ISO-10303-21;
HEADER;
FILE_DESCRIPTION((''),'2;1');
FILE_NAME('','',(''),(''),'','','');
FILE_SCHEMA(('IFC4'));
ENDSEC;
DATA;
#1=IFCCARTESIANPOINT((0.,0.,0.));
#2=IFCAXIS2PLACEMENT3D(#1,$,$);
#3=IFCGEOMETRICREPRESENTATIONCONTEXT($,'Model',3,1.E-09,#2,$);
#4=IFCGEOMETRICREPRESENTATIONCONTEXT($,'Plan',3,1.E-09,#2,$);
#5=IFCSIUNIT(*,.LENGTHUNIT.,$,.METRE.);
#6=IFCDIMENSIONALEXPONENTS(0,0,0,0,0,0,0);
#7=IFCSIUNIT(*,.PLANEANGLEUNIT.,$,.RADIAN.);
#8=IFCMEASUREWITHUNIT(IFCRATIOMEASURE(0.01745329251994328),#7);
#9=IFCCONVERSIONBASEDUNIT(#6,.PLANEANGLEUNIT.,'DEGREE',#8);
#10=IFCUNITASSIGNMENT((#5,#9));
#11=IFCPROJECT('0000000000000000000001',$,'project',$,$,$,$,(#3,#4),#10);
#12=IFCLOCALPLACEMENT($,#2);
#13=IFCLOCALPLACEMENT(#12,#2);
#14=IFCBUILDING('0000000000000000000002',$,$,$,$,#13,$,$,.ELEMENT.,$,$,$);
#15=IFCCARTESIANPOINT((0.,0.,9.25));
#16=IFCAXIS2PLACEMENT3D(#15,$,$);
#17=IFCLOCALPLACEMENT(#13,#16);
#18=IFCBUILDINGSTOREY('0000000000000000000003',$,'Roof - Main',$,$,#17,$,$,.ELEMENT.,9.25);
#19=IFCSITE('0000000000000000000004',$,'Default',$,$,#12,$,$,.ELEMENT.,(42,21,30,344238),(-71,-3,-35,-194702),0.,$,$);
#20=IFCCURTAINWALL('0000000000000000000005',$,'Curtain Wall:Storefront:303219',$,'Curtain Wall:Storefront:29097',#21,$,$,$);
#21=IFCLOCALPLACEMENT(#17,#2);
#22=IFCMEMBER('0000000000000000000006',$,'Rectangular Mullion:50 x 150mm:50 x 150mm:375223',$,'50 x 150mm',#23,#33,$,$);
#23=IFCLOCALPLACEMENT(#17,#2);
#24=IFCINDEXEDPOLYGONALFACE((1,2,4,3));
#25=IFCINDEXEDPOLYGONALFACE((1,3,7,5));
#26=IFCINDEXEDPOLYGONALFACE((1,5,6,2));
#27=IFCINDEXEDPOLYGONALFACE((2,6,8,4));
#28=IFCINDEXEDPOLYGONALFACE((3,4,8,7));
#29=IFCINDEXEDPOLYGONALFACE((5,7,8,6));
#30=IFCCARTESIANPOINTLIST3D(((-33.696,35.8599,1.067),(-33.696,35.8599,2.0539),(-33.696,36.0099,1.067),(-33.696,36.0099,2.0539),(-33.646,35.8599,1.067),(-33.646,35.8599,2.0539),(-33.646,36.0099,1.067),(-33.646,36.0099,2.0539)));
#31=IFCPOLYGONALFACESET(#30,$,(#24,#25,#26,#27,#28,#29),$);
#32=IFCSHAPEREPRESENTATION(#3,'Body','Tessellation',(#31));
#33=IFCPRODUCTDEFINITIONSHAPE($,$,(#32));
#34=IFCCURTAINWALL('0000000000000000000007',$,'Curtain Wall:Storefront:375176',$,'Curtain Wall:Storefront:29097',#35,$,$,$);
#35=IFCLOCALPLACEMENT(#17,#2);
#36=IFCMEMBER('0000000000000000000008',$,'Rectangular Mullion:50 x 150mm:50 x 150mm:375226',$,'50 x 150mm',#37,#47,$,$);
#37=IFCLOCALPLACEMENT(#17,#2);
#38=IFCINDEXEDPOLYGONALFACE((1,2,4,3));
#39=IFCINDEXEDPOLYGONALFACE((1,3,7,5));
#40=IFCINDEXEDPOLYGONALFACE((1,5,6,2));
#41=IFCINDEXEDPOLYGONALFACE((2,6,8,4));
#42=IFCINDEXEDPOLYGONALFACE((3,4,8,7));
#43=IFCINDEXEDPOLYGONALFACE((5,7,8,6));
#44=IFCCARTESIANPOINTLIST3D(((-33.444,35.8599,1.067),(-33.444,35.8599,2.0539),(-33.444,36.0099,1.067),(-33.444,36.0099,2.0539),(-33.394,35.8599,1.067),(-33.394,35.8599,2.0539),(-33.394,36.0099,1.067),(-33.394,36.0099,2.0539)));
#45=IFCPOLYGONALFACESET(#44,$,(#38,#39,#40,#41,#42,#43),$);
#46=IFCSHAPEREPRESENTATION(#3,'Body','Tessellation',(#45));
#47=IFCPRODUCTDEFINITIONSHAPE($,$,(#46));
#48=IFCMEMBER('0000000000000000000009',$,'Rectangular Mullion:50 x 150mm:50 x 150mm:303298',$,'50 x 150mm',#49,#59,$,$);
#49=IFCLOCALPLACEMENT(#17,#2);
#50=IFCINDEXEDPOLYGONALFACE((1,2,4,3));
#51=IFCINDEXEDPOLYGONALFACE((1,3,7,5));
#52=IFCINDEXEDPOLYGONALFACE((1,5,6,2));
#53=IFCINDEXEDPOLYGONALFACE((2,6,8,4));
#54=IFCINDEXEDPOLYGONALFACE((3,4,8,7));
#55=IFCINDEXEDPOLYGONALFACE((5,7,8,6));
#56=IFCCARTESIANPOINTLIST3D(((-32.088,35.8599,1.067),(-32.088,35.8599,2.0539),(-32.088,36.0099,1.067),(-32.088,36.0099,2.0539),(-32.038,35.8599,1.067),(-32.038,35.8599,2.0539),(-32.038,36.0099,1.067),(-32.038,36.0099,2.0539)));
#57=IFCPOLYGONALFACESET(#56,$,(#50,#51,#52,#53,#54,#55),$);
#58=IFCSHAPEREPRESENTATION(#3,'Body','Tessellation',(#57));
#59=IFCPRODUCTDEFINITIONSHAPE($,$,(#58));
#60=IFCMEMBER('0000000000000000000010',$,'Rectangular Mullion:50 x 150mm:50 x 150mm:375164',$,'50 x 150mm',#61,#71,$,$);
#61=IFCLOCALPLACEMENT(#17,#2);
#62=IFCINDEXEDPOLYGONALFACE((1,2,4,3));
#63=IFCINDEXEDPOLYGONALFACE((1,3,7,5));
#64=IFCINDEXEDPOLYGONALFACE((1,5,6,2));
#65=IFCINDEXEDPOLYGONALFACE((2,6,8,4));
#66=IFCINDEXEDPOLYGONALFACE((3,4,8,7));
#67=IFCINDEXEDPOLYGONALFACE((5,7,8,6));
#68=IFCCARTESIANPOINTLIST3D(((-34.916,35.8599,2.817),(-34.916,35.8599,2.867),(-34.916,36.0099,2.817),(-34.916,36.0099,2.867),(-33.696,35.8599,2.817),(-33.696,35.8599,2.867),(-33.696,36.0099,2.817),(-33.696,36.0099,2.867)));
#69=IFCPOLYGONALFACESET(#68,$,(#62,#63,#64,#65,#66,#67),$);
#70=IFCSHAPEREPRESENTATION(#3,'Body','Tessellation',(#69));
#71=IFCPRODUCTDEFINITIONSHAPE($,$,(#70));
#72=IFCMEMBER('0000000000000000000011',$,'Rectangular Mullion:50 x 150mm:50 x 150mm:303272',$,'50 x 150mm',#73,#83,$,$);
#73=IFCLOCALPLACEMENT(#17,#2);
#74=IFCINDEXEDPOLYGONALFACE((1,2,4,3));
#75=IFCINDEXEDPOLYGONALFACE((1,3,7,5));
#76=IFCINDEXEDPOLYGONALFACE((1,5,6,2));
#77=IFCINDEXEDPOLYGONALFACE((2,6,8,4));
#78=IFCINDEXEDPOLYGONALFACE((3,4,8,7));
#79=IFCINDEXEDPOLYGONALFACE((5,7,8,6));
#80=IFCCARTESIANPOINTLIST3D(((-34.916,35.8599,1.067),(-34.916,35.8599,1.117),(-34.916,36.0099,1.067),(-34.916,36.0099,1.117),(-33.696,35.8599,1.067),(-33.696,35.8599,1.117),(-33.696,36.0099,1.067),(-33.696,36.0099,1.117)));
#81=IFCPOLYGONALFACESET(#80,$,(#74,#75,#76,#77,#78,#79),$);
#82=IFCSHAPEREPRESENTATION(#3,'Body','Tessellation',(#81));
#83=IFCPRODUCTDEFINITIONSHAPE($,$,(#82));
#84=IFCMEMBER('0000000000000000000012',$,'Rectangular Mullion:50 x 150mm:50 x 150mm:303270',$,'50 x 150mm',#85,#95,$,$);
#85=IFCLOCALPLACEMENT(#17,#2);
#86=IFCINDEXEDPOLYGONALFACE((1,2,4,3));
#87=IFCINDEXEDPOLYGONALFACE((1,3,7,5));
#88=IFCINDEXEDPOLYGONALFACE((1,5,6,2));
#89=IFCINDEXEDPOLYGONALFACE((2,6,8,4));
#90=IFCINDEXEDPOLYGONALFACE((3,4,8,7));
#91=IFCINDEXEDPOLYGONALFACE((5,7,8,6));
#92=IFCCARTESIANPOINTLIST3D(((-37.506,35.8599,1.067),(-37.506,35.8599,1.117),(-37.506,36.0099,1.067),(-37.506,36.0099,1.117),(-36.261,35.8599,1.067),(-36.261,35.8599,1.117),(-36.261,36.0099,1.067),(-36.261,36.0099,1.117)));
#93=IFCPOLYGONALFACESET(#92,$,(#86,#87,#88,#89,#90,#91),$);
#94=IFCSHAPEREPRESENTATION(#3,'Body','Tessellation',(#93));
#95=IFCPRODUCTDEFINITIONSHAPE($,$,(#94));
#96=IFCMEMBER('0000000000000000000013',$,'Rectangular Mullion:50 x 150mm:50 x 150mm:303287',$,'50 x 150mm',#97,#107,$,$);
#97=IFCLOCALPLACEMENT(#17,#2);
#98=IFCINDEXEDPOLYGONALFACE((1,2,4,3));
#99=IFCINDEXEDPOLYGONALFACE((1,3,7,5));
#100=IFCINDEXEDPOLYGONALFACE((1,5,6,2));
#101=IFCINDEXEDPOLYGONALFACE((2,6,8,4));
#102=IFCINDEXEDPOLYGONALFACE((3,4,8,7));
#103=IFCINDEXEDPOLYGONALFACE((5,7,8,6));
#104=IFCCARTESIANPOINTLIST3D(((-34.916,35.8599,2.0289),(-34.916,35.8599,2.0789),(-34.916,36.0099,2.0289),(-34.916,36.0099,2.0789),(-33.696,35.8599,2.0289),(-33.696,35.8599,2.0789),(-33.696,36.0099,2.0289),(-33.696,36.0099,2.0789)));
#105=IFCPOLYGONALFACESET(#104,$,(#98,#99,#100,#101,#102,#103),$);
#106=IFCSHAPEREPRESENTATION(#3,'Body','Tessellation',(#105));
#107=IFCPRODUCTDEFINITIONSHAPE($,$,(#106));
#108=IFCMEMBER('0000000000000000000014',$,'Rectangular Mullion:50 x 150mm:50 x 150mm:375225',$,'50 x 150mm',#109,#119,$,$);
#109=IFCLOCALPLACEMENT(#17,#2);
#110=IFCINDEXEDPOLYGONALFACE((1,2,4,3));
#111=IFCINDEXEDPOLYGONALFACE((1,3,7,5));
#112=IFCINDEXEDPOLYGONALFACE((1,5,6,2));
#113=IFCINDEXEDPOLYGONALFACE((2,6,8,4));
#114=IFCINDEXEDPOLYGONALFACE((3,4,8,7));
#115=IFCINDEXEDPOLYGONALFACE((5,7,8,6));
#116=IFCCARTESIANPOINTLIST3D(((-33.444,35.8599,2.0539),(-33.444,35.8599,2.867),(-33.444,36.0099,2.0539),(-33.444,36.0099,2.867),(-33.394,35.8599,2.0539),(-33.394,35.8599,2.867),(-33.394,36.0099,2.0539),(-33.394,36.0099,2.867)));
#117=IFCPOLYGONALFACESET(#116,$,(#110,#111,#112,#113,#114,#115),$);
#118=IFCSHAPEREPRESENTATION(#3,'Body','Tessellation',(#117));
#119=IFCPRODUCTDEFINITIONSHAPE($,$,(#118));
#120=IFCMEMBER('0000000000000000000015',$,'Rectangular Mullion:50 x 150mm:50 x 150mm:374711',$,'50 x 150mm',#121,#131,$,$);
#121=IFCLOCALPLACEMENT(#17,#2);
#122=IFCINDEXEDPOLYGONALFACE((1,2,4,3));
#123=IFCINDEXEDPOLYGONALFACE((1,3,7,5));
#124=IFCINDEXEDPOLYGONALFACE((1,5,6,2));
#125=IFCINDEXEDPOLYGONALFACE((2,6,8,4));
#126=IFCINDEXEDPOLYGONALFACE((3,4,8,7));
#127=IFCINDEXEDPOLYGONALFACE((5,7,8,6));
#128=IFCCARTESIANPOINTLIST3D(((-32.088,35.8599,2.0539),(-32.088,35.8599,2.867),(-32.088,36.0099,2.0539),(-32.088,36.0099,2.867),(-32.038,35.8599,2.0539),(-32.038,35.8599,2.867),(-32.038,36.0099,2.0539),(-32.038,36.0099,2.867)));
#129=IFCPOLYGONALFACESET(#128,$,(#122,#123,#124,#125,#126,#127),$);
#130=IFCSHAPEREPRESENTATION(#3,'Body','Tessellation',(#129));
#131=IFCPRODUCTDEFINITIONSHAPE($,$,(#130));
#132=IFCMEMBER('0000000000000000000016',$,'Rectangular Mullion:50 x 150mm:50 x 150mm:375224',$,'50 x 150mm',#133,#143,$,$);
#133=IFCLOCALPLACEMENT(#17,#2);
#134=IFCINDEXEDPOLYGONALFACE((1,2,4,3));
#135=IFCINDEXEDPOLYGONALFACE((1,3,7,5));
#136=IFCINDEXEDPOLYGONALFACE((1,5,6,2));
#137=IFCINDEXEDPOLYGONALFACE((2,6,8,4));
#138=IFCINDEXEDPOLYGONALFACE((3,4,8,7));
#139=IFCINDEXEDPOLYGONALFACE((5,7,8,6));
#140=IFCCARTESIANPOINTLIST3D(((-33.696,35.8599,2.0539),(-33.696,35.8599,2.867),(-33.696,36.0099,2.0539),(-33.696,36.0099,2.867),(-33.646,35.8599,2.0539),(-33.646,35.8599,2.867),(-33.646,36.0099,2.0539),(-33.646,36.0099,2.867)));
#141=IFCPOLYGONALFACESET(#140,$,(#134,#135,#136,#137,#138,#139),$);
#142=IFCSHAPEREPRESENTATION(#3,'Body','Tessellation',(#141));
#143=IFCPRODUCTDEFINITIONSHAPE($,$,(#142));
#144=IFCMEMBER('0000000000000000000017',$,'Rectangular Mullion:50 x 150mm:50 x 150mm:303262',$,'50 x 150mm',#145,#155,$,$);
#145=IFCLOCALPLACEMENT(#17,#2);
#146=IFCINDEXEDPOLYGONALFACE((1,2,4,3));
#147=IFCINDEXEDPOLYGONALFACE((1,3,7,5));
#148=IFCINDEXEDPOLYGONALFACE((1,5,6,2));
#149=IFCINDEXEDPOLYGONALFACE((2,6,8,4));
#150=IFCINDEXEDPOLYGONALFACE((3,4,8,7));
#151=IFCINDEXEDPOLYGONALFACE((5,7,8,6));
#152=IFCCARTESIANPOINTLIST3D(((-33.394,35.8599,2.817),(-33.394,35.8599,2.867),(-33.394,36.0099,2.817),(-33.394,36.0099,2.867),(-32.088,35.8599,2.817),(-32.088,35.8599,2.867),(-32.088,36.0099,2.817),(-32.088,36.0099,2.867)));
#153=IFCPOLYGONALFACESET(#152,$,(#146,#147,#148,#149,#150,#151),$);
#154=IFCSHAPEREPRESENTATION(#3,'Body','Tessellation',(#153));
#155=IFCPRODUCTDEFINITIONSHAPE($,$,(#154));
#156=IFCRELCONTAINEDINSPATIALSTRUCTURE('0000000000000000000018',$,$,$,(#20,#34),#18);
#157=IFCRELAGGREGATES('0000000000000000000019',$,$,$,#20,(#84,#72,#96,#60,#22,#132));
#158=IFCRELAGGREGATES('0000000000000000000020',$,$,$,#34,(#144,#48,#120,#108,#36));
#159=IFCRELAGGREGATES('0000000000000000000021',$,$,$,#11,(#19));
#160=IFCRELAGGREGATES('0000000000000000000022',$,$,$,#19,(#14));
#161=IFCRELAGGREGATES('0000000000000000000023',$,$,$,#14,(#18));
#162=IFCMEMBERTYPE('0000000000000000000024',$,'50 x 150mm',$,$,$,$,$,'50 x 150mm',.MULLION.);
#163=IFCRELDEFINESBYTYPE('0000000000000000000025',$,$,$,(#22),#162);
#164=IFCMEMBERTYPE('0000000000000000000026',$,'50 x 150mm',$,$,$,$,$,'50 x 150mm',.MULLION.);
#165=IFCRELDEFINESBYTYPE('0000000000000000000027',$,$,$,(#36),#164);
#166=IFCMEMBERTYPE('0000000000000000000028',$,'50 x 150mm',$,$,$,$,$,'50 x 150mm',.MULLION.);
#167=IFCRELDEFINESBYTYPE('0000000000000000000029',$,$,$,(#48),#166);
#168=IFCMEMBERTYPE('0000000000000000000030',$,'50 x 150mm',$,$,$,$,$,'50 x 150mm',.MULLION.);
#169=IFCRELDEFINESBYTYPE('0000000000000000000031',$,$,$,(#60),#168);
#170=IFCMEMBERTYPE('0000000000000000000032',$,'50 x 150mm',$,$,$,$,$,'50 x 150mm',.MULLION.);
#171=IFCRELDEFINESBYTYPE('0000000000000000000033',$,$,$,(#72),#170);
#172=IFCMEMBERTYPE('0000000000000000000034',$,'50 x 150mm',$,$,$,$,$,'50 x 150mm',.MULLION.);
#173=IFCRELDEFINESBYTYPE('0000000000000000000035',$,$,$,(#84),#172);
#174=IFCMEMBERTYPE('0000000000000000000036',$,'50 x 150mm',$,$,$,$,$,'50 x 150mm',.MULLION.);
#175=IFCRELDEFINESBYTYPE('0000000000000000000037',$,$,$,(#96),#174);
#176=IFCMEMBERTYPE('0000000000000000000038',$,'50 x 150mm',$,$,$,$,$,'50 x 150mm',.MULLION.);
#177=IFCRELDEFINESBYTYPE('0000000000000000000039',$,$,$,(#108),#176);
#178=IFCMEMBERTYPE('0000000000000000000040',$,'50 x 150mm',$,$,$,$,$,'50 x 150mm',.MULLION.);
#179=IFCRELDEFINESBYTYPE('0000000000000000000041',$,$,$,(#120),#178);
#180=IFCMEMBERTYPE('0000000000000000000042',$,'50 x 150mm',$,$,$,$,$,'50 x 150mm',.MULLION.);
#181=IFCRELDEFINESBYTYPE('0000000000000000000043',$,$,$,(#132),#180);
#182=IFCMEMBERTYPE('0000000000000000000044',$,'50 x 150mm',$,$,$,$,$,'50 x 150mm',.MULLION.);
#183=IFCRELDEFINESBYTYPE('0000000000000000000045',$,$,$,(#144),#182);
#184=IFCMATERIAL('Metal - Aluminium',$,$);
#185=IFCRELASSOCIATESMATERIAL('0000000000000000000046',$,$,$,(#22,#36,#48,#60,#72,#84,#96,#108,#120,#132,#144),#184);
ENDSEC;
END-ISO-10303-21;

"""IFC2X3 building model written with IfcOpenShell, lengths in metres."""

from ifc_helpers import new_model, entity, si_unit, converted_unit, frame, origin, origin_2d_with_axis, place, context, project, spatial, rectangle, extrude, source, transform, mapped, material, type_object, type_shapes, element, aggregate, save


model = new_model("IFC2X3")

# Units and contexts
model_context = context("Model", 3, precision=1e-09, world=origin())
plan_context = context("Plan", 3, precision=1e-09, world=origin())
ifc_project = project(units=[si_unit("LENGTHUNIT", "METRE"), converted_unit("PLANEANGLEUNIT", "DEGREE", entity("IfcRatioMeasure", 0.01745329251994328), si_unit("PLANEANGLEUNIT", "RADIAN"), dimensions=[0, 0, 0, 0, 0, 0, 0])], contexts=[model_context, plan_context])

# Site, building, storey
site_placement = place(None, origin())
site = spatial("IfcSite", under=ifc_project, at=site_placement, Name="Default", CompositionType="ELEMENT", RefLatitude=(42, 21, 30, 344238), RefLongitude=(-71, -3, -35, -194702), RefElevation=0.0)
building_placement = place(site_placement, origin())
building = spatial("IfcBuilding", under=site, at=building_placement, CompositionType="ELEMENT")
storey_placement = place(building_placement, frame((0.0, 0.0, 9.25)))
storey = spatial("IfcBuildingStorey", under=building, at=storey_placement, Name="Roof - Main", CompositionType="ELEMENT", Elevation=9.25)

# Curtain wall, member
curtain_wall_1_placement = place(storey_placement, origin())
curtain_wall_1 = element("IfcCurtainWall", 1, at=curtain_wall_1_placement, inside=storey, Name="Curtain Wall:Storefront:303219", ObjectType="Curtain Wall:Storefront:29097")
ifc_material_1 = material(Name="Metal - Aluminium")
member_type_1 = type_object("IfcMemberType", Name="50 x 150mm", ElementType="50 x 150mm", PredefinedType="MULLION")
shared_shape_1 = source(origin(), model_context, "Body", "SweptSolid", [
    extrude(rectangle(XDim=0.05, YDim=0.15, at=origin_2d_with_axis()), frame((-0.025, 0.0, -0.9869), z_axis=(0.0, 0.0, 1.0), x_axis=(-1.0, 0.0, 0.0)), (0.0, 0.0, 1.0), 0.9869),
])
type_shapes(member_type_1, [shared_shape_1])
member_1_placement = place(storey_placement, frame((-33.646, 35.9349, 1.067), z_axis=(0.0, 0.0, -1.0), x_axis=(1.0, 0.0, 0.0)))
member_1 = element("IfcMember", 2, at=member_1_placement, type_object=member_type_1, material=ifc_material_1, Name="Rectangular Mullion:50 x 150mm:50 x 150mm:375223", ObjectType="50 x 150mm", context=model_context, shape_type="MappedRepresentation", body=[
    mapped(shared_shape_1, transform((0.0, 0.0, 0.0), scale=1.0)),
])

# Curtain wall, members
curtain_wall_2_placement = place(storey_placement, origin())
curtain_wall_2 = element("IfcCurtainWall", 3, at=curtain_wall_2_placement, inside=storey, Name="Curtain Wall:Storefront:375176", ObjectType="Curtain Wall:Storefront:29097")
member_type_2 = type_object("IfcMemberType", Name="50 x 150mm", ElementType="50 x 150mm", PredefinedType="MULLION")
shared_shape_2 = source(origin(), model_context, "Body", "SweptSolid", [
    extrude(rectangle(XDim=0.05, YDim=0.15, at=origin_2d_with_axis()), frame((-0.025, 0.0, -0.9869), z_axis=(0.0, 0.0, 1.0), x_axis=(-1.0, 0.0, 0.0)), (0.0, 0.0, 1.0), 0.9869),
])
type_shapes(member_type_2, [shared_shape_2])
member_2_placement = place(storey_placement, frame((-33.444, 35.9349, 2.0539), z_axis=(0.0, 0.0, 1.0), x_axis=(-1.0, 0.0, 0.0)))
member_2 = element("IfcMember", 4, at=member_2_placement, type_object=member_type_2, material=ifc_material_1, Name="Rectangular Mullion:50 x 150mm:50 x 150mm:375226", ObjectType="50 x 150mm", context=model_context, shape_type="MappedRepresentation", body=[
    mapped(shared_shape_2, transform((0.0, 0.0, 0.0), scale=1.0)),
])
member_type_3 = type_object("IfcMemberType", Name="50 x 150mm", ElementType="50 x 150mm", PredefinedType="MULLION")
shared_shape_3 = source(origin(), model_context, "Body", "SweptSolid", [
    extrude(rectangle(XDim=0.05, YDim=0.15, at=origin_2d_with_axis()), frame((0.0, 0.0, -0.9869), z_axis=(0.0, 0.0, 1.0), x_axis=(-1.0, 0.0, 0.0)), (0.0, 0.0, 1.0), 0.9869),
])
type_shapes(member_type_3, [shared_shape_3])
member_3_placement = place(storey_placement, frame((-32.063, 35.9349, 1.067), z_axis=(0.0, 0.0, -1.0), x_axis=(1.0, 0.0, 0.0)))
member_3 = element("IfcMember", 5, at=member_3_placement, type_object=member_type_3, material=ifc_material_1, Name="Rectangular Mullion:50 x 150mm:50 x 150mm:303298", ObjectType="50 x 150mm", context=model_context, shape_type="MappedRepresentation", body=[
    mapped(shared_shape_3, transform((0.0, 0.0, 0.0), scale=1.0)),
])

# Members
member_type_4 = type_object("IfcMemberType", Name="50 x 150mm", ElementType="50 x 150mm", PredefinedType="MULLION")
shared_shape_4 = source(origin(), model_context, "Body", "SweptSolid", [
    extrude(rectangle(XDim=0.05, YDim=0.15, at=origin_2d_with_axis()), frame((-0.025, 0.0, -1.22), z_axis=(0.0, 0.0, 1.0), x_axis=(-1.0, 0.0, 0.0)), (0.0, 0.0, 1.0), 1.22),
])
type_shapes(member_type_4, [shared_shape_4])
member_4_placement = place(storey_placement, frame((-33.696, 35.9349, 2.867), z_axis=(1.0, 0.0, 0.0), x_axis=(0.0, 0.0, 1.0)))
member_4 = element("IfcMember", 6, at=member_4_placement, type_object=member_type_4, material=ifc_material_1, Name="Rectangular Mullion:50 x 150mm:50 x 150mm:375164", ObjectType="50 x 150mm", context=model_context, shape_type="MappedRepresentation", body=[
    mapped(shared_shape_4, transform((0.0, 0.0, 0.0), scale=1.0)),
])
member_type_5 = type_object("IfcMemberType", Name="50 x 150mm", ElementType="50 x 150mm", PredefinedType="MULLION")
shared_shape_5 = source(origin(), model_context, "Body", "SweptSolid", [
    extrude(rectangle(XDim=0.05, YDim=0.15, at=origin_2d_with_axis()), frame((-0.025, 0.0, -1.22), z_axis=(0.0, 0.0, 1.0), x_axis=(-1.0, 0.0, 0.0)), (0.0, 0.0, 1.0), 1.22),
])
type_shapes(member_type_5, [shared_shape_5])
member_5_placement = place(storey_placement, frame((-34.916, 35.9349, 1.067), z_axis=(-1.0, 0.0, 0.0), x_axis=(0.0, 0.0, -1.0)))
member_5 = element("IfcMember", 7, at=member_5_placement, type_object=member_type_5, material=ifc_material_1, Name="Rectangular Mullion:50 x 150mm:50 x 150mm:303272", ObjectType="50 x 150mm", context=model_context, shape_type="MappedRepresentation", body=[
    mapped(shared_shape_5, transform((0.0, 0.0, 0.0), scale=1.0)),
])
member_type_6 = type_object("IfcMemberType", Name="50 x 150mm", ElementType="50 x 150mm", PredefinedType="MULLION")
shared_shape_6 = source(origin(), model_context, "Body", "SweptSolid", [
    extrude(rectangle(XDim=0.05, YDim=0.15, at=origin_2d_with_axis()), frame((-0.025, 0.0, -1.245), z_axis=(0.0, 0.0, 1.0), x_axis=(-1.0, 0.0, 0.0)), (0.0, 0.0, 1.0), 1.245),
])
type_shapes(member_type_6, [shared_shape_6])
member_6_placement = place(storey_placement, frame((-37.506, 35.9349, 1.067), z_axis=(-1.0, 0.0, 0.0), x_axis=(0.0, 0.0, -1.0)))
member_6 = element("IfcMember", 8, at=member_6_placement, type_object=member_type_6, material=ifc_material_1, Name="Rectangular Mullion:50 x 150mm:50 x 150mm:303270", ObjectType="50 x 150mm", context=model_context, shape_type="MappedRepresentation", body=[
    mapped(shared_shape_6, transform((0.0, 0.0, 0.0), scale=1.0)),
])
member_type_7 = type_object("IfcMemberType", Name="50 x 150mm", ElementType="50 x 150mm", PredefinedType="MULLION")
shared_shape_7 = source(origin(), model_context, "Body", "SweptSolid", [
    extrude(rectangle(XDim=0.05, YDim=0.15, at=origin_2d_with_axis()), frame((0.0, 0.0, -1.22), z_axis=(0.0, 0.0, 1.0), x_axis=(-1.0, 0.0, 0.0)), (0.0, 0.0, 1.0), 1.22),
])
type_shapes(member_type_7, [shared_shape_7])
member_7_placement = place(storey_placement, frame((-33.696, 35.9349, 2.0539), z_axis=(1.0, 0.0, 0.0), x_axis=(0.0, 0.0, 1.0)))
member_7 = element("IfcMember", 9, at=member_7_placement, type_object=member_type_7, material=ifc_material_1, Name="Rectangular Mullion:50 x 150mm:50 x 150mm:303287", ObjectType="50 x 150mm", context=model_context, shape_type="MappedRepresentation", body=[
    mapped(shared_shape_7, transform((0.0, 0.0, 0.0), scale=1.0)),
])
member_type_8 = type_object("IfcMemberType", Name="50 x 150mm", ElementType="50 x 150mm", PredefinedType="MULLION")
shared_shape_8 = source(origin(), model_context, "Body", "SweptSolid", [
    extrude(rectangle(XDim=0.05, YDim=0.15, at=origin_2d_with_axis()), frame((-0.025, 0.0, -0.8131), z_axis=(0.0, 0.0, 1.0), x_axis=(-1.0, 0.0, 0.0)), (0.0, 0.0, 1.0), 0.8131),
])
type_shapes(member_type_8, [shared_shape_8])
member_8_placement = place(storey_placement, frame((-33.444, 35.9349, 2.867), z_axis=(0.0, 0.0, 1.0), x_axis=(-1.0, 0.0, 0.0)))
member_8 = element("IfcMember", 10, at=member_8_placement, type_object=member_type_8, material=ifc_material_1, Name="Rectangular Mullion:50 x 150mm:50 x 150mm:375225", ObjectType="50 x 150mm", context=model_context, shape_type="MappedRepresentation", body=[
    mapped(shared_shape_8, transform((0.0, 0.0, 0.0), scale=1.0)),
])
member_type_9 = type_object("IfcMemberType", Name="50 x 150mm", ElementType="50 x 150mm", PredefinedType="MULLION")
shared_shape_9 = source(origin(), model_context, "Body", "SweptSolid", [
    extrude(rectangle(XDim=0.05, YDim=0.15, at=origin_2d_with_axis()), frame((0.0, 0.0, -0.8131), z_axis=(0.0, 0.0, 1.0), x_axis=(-1.0, 0.0, 0.0)), (0.0, 0.0, 1.0), 0.8131),
])
type_shapes(member_type_9, [shared_shape_9])
member_9_placement = place(storey_placement, frame((-32.063, 35.9349, 2.0539), z_axis=(0.0, 0.0, -1.0), x_axis=(1.0, 0.0, 0.0)))
member_9 = element("IfcMember", 11, at=member_9_placement, type_object=member_type_9, material=ifc_material_1, Name="Rectangular Mullion:50 x 150mm:50 x 150mm:374711", ObjectType="50 x 150mm", context=model_context, shape_type="MappedRepresentation", body=[
    mapped(shared_shape_9, transform((0.0, 0.0, 0.0), scale=1.0)),
])
member_type_10 = type_object("IfcMemberType", Name="50 x 150mm", ElementType="50 x 150mm", PredefinedType="MULLION")
shared_shape_10 = source(origin(), model_context, "Body", "SweptSolid", [
    extrude(rectangle(XDim=0.05, YDim=0.15, at=origin_2d_with_axis()), frame((-0.025, 0.0, -0.8131), z_axis=(0.0, 0.0, 1.0), x_axis=(-1.0, 0.0, 0.0)), (0.0, 0.0, 1.0), 0.8131),
])
type_shapes(member_type_10, [shared_shape_10])
member_10_placement = place(storey_placement, frame((-33.646, 35.9349, 2.0539), z_axis=(0.0, 0.0, -1.0), x_axis=(1.0, 0.0, 0.0)))
member_10 = element("IfcMember", 12, at=member_10_placement, type_object=member_type_10, material=ifc_material_1, Name="Rectangular Mullion:50 x 150mm:50 x 150mm:375224", ObjectType="50 x 150mm", context=model_context, shape_type="MappedRepresentation", body=[
    mapped(shared_shape_10, transform((0.0, 0.0, 0.0), scale=1.0)),
])
member_type_11 = type_object("IfcMemberType", Name="50 x 150mm", ElementType="50 x 150mm", PredefinedType="MULLION")
shared_shape_11 = source(origin(), model_context, "Body", "SweptSolid", [
    extrude(rectangle(XDim=0.05, YDim=0.15, at=origin_2d_with_axis()), frame((-0.025, 0.0, -1.306), z_axis=(0.0, 0.0, 1.0), x_axis=(-1.0, 0.0, 0.0)), (0.0, 0.0, 1.0), 1.306),
])
type_shapes(member_type_11, [shared_shape_11])
member_11_placement = place(storey_placement, frame((-32.088, 35.9349, 2.867), z_axis=(1.0, 0.0, 0.0), x_axis=(0.0, 0.0, 1.0)))
member_11 = element("IfcMember", 13, at=member_11_placement, type_object=member_type_11, material=ifc_material_1, Name="Rectangular Mullion:50 x 150mm:50 x 150mm:303262", ObjectType="50 x 150mm", context=model_context, shape_type="MappedRepresentation", body=[
    mapped(shared_shape_11, transform((0.0, 0.0, 0.0), scale=1.0)),
])

aggregate(curtain_wall_1, [member_6, member_5, member_7, member_4, member_1, member_10])
aggregate(curtain_wall_2, [member_11, member_3, member_9, member_8, member_2])

save(model, "model.ifc")
